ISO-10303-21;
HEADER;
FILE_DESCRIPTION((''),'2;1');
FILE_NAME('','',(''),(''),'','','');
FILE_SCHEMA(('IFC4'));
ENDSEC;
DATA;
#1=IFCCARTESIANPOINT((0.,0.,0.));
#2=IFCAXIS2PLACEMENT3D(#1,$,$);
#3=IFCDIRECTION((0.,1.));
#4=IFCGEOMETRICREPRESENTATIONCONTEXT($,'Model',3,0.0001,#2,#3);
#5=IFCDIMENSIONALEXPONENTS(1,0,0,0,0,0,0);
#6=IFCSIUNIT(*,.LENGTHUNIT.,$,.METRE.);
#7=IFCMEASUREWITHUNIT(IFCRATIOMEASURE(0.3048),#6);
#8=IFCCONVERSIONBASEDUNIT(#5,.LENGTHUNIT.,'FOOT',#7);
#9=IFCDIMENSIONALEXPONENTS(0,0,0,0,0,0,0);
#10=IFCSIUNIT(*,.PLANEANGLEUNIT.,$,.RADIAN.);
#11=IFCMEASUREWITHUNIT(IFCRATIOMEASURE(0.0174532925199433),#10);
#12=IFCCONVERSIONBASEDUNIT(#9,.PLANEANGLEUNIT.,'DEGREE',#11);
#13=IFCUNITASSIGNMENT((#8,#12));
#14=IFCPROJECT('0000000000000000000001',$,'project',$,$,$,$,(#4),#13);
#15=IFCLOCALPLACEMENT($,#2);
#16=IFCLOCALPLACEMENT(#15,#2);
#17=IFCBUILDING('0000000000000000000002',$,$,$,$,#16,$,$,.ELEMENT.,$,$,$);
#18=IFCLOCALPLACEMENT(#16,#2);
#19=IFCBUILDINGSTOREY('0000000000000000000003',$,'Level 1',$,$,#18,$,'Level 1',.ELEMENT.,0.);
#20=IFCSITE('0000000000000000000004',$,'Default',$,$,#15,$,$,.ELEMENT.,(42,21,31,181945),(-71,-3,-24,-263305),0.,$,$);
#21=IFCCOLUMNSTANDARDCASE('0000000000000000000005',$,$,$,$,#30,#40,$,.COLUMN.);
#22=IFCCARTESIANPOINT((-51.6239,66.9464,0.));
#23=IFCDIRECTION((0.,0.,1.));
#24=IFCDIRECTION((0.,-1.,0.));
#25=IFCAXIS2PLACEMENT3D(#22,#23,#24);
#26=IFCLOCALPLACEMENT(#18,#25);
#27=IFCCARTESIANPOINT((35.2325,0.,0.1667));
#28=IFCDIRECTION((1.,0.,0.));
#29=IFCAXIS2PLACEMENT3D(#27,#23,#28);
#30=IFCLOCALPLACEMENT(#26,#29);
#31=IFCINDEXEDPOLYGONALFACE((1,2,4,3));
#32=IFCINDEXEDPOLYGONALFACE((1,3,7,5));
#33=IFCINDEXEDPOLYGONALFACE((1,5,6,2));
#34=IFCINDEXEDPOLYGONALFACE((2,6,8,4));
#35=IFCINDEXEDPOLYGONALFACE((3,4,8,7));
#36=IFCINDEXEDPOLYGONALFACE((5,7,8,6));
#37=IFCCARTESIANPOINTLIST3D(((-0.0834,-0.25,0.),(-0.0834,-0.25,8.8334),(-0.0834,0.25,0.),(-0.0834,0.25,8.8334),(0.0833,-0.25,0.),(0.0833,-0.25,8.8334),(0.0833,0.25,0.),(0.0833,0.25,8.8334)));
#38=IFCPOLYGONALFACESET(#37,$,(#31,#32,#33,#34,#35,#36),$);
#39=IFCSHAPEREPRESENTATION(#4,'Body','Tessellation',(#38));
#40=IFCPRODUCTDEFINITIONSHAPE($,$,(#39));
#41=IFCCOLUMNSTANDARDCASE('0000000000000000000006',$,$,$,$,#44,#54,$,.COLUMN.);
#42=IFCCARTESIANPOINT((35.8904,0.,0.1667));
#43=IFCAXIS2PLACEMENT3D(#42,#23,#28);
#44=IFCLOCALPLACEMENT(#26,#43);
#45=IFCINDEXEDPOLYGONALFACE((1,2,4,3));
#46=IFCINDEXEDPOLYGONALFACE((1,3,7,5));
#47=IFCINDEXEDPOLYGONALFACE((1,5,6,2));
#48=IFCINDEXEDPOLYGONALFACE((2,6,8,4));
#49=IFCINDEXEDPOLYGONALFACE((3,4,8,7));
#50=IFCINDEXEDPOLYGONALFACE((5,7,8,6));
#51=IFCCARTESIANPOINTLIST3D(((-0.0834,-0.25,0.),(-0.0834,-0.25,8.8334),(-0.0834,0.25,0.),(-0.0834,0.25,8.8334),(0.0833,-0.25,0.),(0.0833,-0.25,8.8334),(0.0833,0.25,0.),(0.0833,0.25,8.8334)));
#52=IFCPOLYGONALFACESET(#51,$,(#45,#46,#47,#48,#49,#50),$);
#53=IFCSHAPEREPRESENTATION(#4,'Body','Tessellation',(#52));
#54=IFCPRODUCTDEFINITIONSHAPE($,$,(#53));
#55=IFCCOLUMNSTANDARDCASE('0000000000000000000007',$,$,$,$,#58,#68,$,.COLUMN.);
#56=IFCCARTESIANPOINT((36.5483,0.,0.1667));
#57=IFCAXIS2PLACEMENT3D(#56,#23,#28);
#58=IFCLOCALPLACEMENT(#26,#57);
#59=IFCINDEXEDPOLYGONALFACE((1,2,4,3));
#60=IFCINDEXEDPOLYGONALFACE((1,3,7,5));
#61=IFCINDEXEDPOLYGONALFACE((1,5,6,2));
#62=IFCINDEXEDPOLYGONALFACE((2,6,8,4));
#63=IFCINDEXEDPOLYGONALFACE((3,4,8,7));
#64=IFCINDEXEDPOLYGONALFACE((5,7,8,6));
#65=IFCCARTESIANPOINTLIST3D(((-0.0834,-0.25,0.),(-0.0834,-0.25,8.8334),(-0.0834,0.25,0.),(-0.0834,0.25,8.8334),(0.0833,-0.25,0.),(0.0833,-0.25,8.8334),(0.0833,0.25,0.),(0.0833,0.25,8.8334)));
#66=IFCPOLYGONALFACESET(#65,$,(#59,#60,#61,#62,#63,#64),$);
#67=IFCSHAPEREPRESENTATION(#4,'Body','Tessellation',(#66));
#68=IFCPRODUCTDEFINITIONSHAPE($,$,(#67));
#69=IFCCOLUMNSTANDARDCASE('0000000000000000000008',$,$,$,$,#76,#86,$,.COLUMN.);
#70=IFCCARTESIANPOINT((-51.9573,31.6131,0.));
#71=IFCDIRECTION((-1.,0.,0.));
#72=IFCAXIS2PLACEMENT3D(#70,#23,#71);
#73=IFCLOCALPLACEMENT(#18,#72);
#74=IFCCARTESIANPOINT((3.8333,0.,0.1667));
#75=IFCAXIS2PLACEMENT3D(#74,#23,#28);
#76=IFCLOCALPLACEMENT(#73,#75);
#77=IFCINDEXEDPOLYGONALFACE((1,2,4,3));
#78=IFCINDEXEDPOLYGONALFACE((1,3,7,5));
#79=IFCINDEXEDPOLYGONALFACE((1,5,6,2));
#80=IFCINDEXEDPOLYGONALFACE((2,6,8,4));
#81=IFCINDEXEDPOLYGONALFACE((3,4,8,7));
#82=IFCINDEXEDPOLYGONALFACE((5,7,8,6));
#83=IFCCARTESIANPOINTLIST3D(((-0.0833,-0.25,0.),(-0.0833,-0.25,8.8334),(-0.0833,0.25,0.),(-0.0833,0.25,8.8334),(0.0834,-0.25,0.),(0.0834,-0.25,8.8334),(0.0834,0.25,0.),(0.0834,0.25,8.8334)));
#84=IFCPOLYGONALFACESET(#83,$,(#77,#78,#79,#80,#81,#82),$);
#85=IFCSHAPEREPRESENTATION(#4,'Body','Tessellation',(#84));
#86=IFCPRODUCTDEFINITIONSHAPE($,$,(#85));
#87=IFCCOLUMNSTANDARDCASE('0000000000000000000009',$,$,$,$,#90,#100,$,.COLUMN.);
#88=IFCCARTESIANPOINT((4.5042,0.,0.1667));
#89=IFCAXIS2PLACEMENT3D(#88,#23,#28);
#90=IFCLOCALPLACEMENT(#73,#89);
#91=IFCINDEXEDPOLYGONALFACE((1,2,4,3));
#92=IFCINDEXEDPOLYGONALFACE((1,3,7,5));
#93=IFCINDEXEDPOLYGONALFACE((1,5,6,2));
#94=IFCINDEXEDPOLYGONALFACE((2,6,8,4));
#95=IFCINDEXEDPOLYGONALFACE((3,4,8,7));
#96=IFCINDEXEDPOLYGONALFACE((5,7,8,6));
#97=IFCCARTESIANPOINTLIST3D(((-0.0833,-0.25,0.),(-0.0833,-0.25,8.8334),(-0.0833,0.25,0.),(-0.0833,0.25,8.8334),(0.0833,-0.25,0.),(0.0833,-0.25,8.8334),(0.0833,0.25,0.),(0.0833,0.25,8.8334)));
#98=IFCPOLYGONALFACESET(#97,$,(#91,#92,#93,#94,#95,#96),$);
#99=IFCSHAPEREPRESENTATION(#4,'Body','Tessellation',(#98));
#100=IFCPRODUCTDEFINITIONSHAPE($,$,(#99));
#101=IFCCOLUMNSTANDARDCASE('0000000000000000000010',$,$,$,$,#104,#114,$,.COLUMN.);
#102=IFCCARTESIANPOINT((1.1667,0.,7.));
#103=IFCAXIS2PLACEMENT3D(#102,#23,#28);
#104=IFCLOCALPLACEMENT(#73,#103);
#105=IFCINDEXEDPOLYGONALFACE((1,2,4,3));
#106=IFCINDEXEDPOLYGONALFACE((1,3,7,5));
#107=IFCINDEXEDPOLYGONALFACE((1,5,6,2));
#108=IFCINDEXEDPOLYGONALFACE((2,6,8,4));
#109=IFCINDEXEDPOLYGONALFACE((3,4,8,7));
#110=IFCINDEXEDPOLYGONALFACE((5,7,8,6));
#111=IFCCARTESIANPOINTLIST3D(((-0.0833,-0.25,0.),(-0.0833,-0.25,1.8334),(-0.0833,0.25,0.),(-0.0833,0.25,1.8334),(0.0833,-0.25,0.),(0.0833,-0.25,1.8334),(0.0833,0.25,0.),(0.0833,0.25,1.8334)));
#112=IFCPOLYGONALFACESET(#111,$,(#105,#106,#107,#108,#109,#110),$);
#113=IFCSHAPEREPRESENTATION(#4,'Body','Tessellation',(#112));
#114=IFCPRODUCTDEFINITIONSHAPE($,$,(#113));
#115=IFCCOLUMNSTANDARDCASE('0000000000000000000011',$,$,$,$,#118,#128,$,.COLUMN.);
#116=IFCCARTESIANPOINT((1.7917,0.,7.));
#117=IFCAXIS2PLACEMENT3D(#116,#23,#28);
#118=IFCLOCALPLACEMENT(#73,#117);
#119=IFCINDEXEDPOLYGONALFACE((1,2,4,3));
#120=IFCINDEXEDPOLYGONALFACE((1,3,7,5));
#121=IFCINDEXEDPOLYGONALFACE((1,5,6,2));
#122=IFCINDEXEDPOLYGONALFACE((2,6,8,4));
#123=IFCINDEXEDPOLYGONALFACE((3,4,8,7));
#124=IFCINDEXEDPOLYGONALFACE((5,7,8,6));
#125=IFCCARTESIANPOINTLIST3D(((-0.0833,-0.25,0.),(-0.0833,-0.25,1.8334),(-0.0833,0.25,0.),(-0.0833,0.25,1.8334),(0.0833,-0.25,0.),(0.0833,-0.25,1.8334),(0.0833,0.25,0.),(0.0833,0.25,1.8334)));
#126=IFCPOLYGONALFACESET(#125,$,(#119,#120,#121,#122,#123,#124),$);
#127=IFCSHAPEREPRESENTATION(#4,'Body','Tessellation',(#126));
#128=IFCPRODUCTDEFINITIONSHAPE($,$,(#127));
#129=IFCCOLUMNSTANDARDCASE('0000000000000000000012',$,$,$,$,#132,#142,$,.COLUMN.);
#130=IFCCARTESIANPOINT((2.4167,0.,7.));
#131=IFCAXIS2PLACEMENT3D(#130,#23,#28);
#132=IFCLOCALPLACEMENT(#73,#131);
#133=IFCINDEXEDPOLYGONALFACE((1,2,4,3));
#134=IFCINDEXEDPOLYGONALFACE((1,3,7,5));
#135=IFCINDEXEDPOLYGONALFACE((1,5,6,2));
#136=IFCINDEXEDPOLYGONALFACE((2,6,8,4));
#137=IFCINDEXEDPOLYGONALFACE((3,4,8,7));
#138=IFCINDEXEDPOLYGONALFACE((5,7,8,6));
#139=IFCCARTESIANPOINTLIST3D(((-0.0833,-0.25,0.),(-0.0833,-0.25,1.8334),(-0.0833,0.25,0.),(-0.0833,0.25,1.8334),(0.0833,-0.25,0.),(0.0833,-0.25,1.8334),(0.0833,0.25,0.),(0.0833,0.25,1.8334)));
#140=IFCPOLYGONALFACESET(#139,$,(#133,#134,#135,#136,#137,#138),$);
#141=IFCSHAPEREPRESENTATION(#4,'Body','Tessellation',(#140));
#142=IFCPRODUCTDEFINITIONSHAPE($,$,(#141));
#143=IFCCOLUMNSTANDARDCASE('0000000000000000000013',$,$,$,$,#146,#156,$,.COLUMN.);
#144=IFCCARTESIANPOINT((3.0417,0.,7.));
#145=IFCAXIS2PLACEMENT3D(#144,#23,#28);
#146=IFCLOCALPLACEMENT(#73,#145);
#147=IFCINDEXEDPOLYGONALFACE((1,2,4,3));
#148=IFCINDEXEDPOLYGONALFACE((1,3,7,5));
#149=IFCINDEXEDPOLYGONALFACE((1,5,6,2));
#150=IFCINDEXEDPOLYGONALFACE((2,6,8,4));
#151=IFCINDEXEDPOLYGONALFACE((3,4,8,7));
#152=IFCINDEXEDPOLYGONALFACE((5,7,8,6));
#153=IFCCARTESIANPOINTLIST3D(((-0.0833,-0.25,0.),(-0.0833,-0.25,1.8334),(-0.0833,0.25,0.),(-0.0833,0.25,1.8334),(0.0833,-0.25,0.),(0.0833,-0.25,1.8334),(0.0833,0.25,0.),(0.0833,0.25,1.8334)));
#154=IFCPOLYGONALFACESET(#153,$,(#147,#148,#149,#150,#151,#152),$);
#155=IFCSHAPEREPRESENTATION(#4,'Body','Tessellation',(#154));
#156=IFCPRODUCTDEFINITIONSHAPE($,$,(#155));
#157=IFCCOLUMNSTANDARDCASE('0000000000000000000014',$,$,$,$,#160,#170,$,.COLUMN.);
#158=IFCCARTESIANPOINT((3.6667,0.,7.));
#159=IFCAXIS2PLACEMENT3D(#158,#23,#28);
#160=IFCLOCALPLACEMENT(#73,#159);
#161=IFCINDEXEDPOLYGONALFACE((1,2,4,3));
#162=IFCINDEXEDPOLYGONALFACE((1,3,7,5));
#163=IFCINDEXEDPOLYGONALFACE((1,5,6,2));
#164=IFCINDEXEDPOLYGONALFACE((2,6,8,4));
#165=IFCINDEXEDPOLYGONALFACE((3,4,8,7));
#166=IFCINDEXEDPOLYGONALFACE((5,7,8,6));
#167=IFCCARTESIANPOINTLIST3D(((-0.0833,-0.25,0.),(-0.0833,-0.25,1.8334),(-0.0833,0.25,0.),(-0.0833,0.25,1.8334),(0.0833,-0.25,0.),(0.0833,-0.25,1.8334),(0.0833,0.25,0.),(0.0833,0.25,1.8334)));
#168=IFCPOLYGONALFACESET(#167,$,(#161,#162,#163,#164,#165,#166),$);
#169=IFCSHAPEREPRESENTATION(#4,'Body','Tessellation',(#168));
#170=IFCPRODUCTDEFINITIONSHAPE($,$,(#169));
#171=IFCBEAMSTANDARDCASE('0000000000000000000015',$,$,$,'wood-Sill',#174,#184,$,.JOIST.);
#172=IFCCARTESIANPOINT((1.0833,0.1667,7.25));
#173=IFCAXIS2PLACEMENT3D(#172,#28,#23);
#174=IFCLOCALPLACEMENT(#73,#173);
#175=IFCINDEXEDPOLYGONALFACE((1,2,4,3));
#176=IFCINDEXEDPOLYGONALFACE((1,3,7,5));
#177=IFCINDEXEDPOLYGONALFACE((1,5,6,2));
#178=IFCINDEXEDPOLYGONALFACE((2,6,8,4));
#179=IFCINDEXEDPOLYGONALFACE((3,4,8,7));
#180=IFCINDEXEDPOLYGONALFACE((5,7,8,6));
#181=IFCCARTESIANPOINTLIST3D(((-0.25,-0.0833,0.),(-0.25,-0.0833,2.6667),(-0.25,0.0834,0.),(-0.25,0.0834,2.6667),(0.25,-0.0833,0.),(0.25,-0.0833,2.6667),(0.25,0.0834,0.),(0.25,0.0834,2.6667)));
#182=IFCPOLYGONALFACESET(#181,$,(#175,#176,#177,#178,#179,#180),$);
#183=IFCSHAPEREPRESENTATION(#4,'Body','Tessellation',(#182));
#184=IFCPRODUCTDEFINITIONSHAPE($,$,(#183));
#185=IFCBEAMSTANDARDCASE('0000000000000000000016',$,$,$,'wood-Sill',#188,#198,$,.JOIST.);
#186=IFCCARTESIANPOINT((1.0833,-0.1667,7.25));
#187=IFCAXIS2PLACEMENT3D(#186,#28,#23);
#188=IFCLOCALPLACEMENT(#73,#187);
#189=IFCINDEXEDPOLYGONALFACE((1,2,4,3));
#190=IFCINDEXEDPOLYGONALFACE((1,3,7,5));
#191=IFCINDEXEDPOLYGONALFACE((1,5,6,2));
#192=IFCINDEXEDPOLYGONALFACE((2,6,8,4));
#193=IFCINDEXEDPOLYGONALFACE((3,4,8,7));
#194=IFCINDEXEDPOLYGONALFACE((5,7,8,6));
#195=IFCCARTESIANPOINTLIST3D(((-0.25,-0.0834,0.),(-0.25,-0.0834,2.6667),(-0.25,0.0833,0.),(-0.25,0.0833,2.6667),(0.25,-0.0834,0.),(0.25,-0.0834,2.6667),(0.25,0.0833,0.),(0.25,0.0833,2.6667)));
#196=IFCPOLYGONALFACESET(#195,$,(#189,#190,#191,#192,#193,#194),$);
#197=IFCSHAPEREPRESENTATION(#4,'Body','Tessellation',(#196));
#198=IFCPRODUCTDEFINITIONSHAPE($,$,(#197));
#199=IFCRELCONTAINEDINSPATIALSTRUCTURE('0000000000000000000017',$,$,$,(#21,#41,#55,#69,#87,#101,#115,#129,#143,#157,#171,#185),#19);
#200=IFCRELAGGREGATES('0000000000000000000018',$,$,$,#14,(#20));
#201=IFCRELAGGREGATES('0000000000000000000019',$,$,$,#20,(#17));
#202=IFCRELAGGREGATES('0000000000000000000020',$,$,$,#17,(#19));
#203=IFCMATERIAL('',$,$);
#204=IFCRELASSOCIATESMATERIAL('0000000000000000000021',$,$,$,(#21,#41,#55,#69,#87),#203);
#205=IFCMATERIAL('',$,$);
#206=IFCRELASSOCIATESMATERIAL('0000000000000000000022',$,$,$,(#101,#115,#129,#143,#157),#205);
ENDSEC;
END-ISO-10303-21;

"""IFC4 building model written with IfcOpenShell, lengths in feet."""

from ifc_helpers import new_model, entity, si_unit, converted_unit, direction, frame, origin, origin_with_axes, place, context, project, spatial, rectangle, extrude, material, element, save


model = new_model("IFC4")

# Units and contexts
model_context = context("Model", 3, precision=0.0001, world=origin(), true_north=direction((0.0, 1.0)))
ifc_project = project(units=[converted_unit("LENGTHUNIT", "FOOT", entity("IfcRatioMeasure", 0.3048), si_unit("LENGTHUNIT", "METRE"), dimensions=[1, 0, 0, 0, 0, 0, 0]), converted_unit("PLANEANGLEUNIT", "DEGREE", entity("IfcRatioMeasure", 0.0174532925199433), si_unit("PLANEANGLEUNIT", "RADIAN"), dimensions=[0, 0, 0, 0, 0, 0, 0])], contexts=[model_context])

# Site, building, storey
site_placement = place(None, origin())
site = spatial("IfcSite", under=ifc_project, at=site_placement, Name="Default", CompositionType="ELEMENT", RefLatitude=(42, 21, 31, 181945), RefLongitude=(-71, -3, -24, -263305), RefElevation=0.0)
building_placement = place(site_placement, origin())
building = spatial("IfcBuilding", under=site, at=building_placement, CompositionType="ELEMENT")
storey_placement = place(building_placement, origin())
storey = spatial("IfcBuildingStorey", under=building, at=storey_placement, Name="Level 1", LongName="Level 1", CompositionType="ELEMENT", Elevation=0.0)

# Columns
ifc_material_1 = material(Name="")
placement_1 = place(storey_placement, frame((-51.6239, 66.9464, 0.0), z_axis=(0.0, 0.0, 1.0), x_axis=(0.0, -1.0, 0.0)))
for number, where, z_axis, x_axis in (
    (1, (35.2325, 0.0, 0.1667), (0.0, 0.0, 1.0), (1.0, 0.0, 0.0)),
    (2, (35.8904, 0.0, 0.1667), (0.0, 0.0, 1.0), (1.0, 0.0, 0.0)),
    (3, (36.5483, 0.0, 0.1667), (0.0, 0.0, 1.0), (1.0, 0.0, 0.0)),
):
    element("IfcColumnStandardCase", number, at=place(placement_1, frame(where, z_axis=z_axis, x_axis=x_axis)), inside=storey, material=ifc_material_1, PredefinedType="COLUMN", context=model_context, shape_type="SweptSolid", body=[
        extrude(rectangle(XDim=0.1667, YDim=0.5), origin(), (0.0, 0.0, 1.0), 8.8334),
    ])
placement_2 = place(storey_placement, frame((-51.9573, 31.6131, 0.0), z_axis=(0.0, 0.0, 1.0), x_axis=(-1.0, 0.0, 0.0)))
for number, where, z_axis, x_axis in (
    (4, (3.8333, 0.0, 0.1667), (0.0, 0.0, 1.0), (1.0, 0.0, 0.0)),
    (5, (4.5042, 0.0, 0.1667), (0.0, 0.0, 1.0), (1.0, 0.0, 0.0)),
):
    element("IfcColumnStandardCase", number, at=place(placement_2, frame(where, z_axis=z_axis, x_axis=x_axis)), inside=storey, material=ifc_material_1, PredefinedType="COLUMN", context=model_context, shape_type="SweptSolid", body=[
        extrude(rectangle(XDim=0.1667, YDim=0.5), origin(), (0.0, 0.0, 1.0), 8.8334),
    ])
ifc_material_2 = material(Name="")
for number, where, z_axis, x_axis in (
    (6, (1.1667, 0.0, 7.0), (0.0, 0.0, 1.0), (1.0, 0.0, 0.0)),
    (7, (1.7917, 0.0, 7.0), (0.0, 0.0, 1.0), (1.0, 0.0, 0.0)),
    (8, (2.4167, 0.0, 7.0), (0.0, 0.0, 1.0), (1.0, 0.0, 0.0)),
    (9, (3.0417, 0.0, 7.0), (0.0, 0.0, 1.0), (1.0, 0.0, 0.0)),
    (10, (3.6667, 0.0, 7.0), (0.0, 0.0, 1.0), (1.0, 0.0, 0.0)),
):
    element("IfcColumnStandardCase", number, at=place(placement_2, frame(where, z_axis=z_axis, x_axis=x_axis)), inside=storey, material=ifc_material_2, PredefinedType="COLUMN", context=model_context, shape_type="SweptSolid", body=[
        extrude(rectangle(XDim=0.1667, YDim=0.5), origin(), (0.0, 0.0, 1.0), 1.8334),
    ])

# Beams
for number, where, z_axis, x_axis in (
    (11, (1.0833, 0.1667, 7.25), (1.0, 0.0, 0.0), (0.0, 0.0, 1.0)),
    (12, (1.0833, -0.1667, 7.25), (1.0, 0.0, 0.0), (0.0, 0.0, 1.0)),
):
    element("IfcBeamStandardCase", number, at=place(placement_2, frame(where, z_axis=z_axis, x_axis=x_axis)), inside=storey, ObjectType="wood-Sill", PredefinedType="JOIST", context=model_context, shape_type="SweptSolid", body=[
        extrude(rectangle(XDim=0.5, YDim=0.1667), origin_with_axes(), (0.0, 0.0, 1.0), 2.6667),
    ])

save(model, "model.ifc")
